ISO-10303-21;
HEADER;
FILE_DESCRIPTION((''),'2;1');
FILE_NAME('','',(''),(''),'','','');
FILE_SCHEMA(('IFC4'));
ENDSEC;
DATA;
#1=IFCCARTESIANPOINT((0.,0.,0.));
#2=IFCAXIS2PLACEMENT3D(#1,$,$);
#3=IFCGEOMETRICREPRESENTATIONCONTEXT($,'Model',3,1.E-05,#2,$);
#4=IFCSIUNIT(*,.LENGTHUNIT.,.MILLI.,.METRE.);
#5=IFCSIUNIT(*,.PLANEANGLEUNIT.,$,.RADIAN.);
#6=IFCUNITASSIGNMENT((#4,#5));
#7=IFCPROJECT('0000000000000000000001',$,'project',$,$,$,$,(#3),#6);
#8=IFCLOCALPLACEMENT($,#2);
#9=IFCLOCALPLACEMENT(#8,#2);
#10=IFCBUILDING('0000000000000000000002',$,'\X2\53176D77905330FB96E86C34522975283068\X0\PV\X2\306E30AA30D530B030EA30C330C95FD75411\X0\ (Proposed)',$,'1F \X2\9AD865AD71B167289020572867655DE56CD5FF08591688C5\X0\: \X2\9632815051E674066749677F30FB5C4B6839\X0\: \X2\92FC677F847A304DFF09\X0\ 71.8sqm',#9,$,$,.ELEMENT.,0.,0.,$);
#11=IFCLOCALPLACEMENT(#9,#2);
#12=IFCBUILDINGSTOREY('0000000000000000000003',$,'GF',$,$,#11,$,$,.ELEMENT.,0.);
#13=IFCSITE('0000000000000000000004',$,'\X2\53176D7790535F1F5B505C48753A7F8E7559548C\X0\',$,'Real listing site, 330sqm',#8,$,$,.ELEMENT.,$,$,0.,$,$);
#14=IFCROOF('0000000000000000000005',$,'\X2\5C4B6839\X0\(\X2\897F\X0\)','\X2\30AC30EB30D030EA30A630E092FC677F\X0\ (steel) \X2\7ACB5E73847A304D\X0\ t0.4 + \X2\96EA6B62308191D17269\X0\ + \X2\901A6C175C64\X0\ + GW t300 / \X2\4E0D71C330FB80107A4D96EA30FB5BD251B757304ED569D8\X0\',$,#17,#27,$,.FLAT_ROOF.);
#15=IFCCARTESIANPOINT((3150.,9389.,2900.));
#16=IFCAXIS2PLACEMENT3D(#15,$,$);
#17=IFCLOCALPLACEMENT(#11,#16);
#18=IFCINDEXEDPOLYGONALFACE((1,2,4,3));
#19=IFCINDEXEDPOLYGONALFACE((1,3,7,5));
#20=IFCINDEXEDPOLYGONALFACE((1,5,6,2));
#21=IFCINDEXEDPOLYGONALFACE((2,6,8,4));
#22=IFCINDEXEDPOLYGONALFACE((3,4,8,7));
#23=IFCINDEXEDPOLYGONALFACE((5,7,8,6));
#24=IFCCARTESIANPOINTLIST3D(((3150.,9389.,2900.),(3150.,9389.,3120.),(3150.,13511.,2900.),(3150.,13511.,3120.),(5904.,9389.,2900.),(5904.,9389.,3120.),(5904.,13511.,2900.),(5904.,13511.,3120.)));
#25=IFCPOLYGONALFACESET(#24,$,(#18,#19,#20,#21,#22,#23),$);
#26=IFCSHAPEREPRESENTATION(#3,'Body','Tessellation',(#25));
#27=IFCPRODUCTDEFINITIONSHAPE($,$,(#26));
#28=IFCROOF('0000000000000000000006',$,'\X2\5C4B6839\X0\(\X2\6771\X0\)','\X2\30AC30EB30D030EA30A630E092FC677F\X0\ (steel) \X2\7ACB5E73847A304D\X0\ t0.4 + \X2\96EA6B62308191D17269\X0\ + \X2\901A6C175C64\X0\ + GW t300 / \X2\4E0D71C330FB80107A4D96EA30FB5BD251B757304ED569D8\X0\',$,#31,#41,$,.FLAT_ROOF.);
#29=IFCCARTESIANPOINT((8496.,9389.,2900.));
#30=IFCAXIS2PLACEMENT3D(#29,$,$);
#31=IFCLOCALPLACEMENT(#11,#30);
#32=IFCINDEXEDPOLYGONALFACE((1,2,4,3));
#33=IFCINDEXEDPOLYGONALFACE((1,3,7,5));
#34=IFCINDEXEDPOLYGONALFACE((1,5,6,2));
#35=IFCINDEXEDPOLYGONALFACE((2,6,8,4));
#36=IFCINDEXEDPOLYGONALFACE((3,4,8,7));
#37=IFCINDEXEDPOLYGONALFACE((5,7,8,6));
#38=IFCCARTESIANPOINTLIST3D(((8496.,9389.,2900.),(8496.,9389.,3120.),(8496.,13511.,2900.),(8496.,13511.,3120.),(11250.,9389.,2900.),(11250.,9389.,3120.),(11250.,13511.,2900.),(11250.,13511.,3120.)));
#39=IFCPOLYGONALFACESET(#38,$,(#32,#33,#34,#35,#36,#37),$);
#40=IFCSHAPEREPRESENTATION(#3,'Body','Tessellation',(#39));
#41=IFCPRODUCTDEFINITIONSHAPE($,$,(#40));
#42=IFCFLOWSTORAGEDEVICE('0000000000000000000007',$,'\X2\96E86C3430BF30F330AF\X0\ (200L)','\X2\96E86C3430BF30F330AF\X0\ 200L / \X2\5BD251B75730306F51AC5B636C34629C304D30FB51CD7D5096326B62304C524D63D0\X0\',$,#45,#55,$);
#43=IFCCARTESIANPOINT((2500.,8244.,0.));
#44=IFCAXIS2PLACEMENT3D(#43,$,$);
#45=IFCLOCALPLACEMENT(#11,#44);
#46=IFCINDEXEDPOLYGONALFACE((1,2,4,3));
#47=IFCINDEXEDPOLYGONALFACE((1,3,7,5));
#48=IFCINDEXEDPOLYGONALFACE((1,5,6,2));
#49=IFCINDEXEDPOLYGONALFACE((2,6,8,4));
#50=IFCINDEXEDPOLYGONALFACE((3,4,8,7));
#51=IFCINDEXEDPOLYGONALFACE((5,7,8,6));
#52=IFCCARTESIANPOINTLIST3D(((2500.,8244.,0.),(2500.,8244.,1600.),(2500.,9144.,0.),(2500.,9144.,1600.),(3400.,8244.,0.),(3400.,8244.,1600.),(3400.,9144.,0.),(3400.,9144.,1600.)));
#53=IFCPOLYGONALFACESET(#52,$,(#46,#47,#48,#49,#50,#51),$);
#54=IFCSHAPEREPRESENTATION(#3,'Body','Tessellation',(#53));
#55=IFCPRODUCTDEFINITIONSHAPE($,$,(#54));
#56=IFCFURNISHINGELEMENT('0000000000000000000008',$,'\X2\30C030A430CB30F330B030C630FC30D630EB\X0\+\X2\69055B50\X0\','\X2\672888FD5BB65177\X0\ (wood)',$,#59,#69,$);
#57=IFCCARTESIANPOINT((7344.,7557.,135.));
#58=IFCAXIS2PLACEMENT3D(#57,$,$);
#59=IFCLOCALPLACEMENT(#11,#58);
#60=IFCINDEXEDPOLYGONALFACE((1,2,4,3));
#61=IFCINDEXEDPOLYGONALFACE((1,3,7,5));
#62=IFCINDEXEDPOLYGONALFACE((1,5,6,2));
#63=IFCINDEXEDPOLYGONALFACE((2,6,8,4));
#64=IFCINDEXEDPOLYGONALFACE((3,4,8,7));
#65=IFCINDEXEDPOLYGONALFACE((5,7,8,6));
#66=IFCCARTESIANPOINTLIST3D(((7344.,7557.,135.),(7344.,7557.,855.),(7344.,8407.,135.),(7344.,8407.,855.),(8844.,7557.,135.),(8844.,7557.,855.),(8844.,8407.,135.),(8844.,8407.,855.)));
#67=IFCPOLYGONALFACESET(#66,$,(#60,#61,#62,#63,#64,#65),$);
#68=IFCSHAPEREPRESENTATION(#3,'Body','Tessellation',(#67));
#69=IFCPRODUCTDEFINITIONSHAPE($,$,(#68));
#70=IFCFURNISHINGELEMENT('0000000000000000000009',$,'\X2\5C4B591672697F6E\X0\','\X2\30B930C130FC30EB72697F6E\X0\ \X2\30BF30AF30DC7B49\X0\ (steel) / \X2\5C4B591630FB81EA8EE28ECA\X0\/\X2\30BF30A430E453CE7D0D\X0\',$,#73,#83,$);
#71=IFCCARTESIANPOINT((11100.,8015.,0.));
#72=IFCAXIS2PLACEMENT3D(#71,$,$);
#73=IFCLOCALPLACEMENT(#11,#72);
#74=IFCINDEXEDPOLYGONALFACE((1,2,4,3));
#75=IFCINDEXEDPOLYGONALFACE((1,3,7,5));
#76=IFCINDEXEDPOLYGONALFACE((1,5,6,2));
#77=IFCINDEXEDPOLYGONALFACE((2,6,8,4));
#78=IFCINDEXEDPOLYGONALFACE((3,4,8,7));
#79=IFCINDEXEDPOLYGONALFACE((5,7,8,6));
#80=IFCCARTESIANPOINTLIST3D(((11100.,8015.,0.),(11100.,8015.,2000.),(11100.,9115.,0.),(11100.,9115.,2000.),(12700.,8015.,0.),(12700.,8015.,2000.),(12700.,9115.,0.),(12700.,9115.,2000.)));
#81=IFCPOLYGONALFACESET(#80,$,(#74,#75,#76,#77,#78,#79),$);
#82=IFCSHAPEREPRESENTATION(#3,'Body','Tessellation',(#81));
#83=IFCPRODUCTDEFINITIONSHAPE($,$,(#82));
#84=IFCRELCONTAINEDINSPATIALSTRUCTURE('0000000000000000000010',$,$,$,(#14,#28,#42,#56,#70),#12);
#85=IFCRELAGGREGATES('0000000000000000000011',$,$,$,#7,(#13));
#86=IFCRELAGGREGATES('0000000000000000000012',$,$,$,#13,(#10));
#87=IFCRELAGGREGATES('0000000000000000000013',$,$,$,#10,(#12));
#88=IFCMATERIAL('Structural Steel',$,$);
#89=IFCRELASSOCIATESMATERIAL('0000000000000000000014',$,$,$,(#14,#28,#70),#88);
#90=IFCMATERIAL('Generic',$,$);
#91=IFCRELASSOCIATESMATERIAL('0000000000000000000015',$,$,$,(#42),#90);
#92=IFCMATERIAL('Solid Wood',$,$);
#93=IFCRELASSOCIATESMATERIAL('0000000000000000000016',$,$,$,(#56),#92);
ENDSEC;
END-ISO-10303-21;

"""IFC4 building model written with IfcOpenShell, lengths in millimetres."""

from ifc_helpers import new_model, si_unit, frame, frame_2d, origin, place, context, project, spatial, rectangle, extrude, material, element, save


model = new_model("IFC4")

# Units and contexts
model_context = context("Model", 3, precision=1e-05, world=origin())
ifc_project = project(units=[si_unit("LENGTHUNIT", "METRE", prefix="MILLI"), si_unit("PLANEANGLEUNIT", "RADIAN")], contexts=[model_context])

# Site, building, storey
site_placement = place(None, origin())
site = spatial("IfcSite", under=ifc_project, at=site_placement, Name="北海道弟子屈町美留和", ObjectType="Real listing site, 330sqm", CompositionType="ELEMENT", RefElevation=0.0)
building_placement = place(site_placement, origin())
building = spatial("IfcBuilding", under=site, at=building_placement, Name="北海道・雨水利用とPVのオフグリッド志向 (Proposed)", ObjectType="1F 高断熱木造在来工法（外装: 防腐処理杉板・屋根: 鋼板葺き） 71.8sqm", CompositionType="ELEMENT", ElevationOfRefHeight=0.0, ElevationOfTerrain=0.0)
storey_placement = place(building_placement, origin())
storey = spatial("IfcBuildingStorey", under=building, at=storey_placement, Name="GF", CompositionType="ELEMENT", Elevation=0.0)

# Shared definitions
ifc_material_1 = material(Name="Solid Wood")

# Roofs
ifc_material_2 = material(Name="Structural Steel")
roof_1_placement = place(storey_placement, frame((3150.0, 9389.0, 2900.0)))
element("IfcRoof", 1, at=roof_1_placement, inside=storey, material=ifc_material_2, Name="屋根(西)", Description="ガルバリウム鋼板 (steel) 立平葺き t0.4 + 雪止め金物 + 通気層 + GW t300 / 不燃・耐積雪・寒冷地仕様", PredefinedType="FLAT_ROOF", context=model_context, shape_type="SweptSolid", body=[
    extrude(rectangle(XDim=2754.0, YDim=4122.0, at=frame_2d((1377.0, 2061.0))), frame((3150.0, 9389.0, 2900.0)), (0.0, 0.0, 1.0), 220.0),
])
roof_2_placement = place(storey_placement, frame((8496.0, 9389.0, 2900.0)))
element("IfcRoof", 2, at=roof_2_placement, inside=storey, material=ifc_material_2, Name="屋根(東)", Description="ガルバリウム鋼板 (steel) 立平葺き t0.4 + 雪止め金物 + 通気層 + GW t300 / 不燃・耐積雪・寒冷地仕様", PredefinedType="FLAT_ROOF", context=model_context, shape_type="SweptSolid", body=[
    extrude(rectangle(XDim=2754.0, YDim=4122.0, at=frame_2d((1377.0, 2061.0))), frame((8496.0, 9389.0, 2900.0)), (0.0, 0.0, 1.0), 220.0),
])

# Flow storage device
ifc_material_3 = material(Name="Generic")
flow_storage_device_placement = place(storey_placement, frame((2500.0, 8244.0, 0.0)))
element("IfcFlowStorageDevice", 3, at=flow_storage_device_placement, inside=storey, material=ifc_material_3, Name="雨水タンク (200L)", Description="雨水タンク 200L / 寒冷地は冬季水抜き・凍結防止が前提", context=model_context, shape_type="SweptSolid", body=[
    extrude(rectangle(XDim=900.0, YDim=900.0, at=frame_2d((450.0, 450.0))), frame((2500.0, 8244.0, 0.0)), (0.0, 0.0, 1.0), 1600.0),
])

# Furnishing elements
furnishing_1_placement = place(storey_placement, frame((7344.0, 7557.0, 135.0)))
element("IfcFurnishingElement", 4, at=furnishing_1_placement, inside=storey, material=ifc_material_1, Name="ダイニングテーブル+椅子", Description="木製家具 (wood)", context=model_context, shape_type="SweptSolid", body=[
    extrude(rectangle(XDim=1500.0, YDim=850.0, at=frame_2d((750.0, 425.0))), frame((7344.0, 7557.0, 135.0)), (0.0, 0.0, 1.0), 720.0),
])
furnishing_2_placement = place(storey_placement, frame((11100.0, 8015.0, 0.0)))
element("IfcFurnishingElement", 5, at=furnishing_2_placement, inside=storey, material=ifc_material_2, Name="屋外物置", Description="スチール物置 タクボ等 (steel) / 屋外・自転車/タイヤ収納", context=model_context, shape_type="SweptSolid", body=[
    extrude(rectangle(XDim=1600.0, YDim=1100.0, at=frame_2d((800.0, 550.0))), frame((11100.0, 8015.0, 0.0)), (0.0, 0.0, 1.0), 2000.0),
])

save(model, "model.ifc")
